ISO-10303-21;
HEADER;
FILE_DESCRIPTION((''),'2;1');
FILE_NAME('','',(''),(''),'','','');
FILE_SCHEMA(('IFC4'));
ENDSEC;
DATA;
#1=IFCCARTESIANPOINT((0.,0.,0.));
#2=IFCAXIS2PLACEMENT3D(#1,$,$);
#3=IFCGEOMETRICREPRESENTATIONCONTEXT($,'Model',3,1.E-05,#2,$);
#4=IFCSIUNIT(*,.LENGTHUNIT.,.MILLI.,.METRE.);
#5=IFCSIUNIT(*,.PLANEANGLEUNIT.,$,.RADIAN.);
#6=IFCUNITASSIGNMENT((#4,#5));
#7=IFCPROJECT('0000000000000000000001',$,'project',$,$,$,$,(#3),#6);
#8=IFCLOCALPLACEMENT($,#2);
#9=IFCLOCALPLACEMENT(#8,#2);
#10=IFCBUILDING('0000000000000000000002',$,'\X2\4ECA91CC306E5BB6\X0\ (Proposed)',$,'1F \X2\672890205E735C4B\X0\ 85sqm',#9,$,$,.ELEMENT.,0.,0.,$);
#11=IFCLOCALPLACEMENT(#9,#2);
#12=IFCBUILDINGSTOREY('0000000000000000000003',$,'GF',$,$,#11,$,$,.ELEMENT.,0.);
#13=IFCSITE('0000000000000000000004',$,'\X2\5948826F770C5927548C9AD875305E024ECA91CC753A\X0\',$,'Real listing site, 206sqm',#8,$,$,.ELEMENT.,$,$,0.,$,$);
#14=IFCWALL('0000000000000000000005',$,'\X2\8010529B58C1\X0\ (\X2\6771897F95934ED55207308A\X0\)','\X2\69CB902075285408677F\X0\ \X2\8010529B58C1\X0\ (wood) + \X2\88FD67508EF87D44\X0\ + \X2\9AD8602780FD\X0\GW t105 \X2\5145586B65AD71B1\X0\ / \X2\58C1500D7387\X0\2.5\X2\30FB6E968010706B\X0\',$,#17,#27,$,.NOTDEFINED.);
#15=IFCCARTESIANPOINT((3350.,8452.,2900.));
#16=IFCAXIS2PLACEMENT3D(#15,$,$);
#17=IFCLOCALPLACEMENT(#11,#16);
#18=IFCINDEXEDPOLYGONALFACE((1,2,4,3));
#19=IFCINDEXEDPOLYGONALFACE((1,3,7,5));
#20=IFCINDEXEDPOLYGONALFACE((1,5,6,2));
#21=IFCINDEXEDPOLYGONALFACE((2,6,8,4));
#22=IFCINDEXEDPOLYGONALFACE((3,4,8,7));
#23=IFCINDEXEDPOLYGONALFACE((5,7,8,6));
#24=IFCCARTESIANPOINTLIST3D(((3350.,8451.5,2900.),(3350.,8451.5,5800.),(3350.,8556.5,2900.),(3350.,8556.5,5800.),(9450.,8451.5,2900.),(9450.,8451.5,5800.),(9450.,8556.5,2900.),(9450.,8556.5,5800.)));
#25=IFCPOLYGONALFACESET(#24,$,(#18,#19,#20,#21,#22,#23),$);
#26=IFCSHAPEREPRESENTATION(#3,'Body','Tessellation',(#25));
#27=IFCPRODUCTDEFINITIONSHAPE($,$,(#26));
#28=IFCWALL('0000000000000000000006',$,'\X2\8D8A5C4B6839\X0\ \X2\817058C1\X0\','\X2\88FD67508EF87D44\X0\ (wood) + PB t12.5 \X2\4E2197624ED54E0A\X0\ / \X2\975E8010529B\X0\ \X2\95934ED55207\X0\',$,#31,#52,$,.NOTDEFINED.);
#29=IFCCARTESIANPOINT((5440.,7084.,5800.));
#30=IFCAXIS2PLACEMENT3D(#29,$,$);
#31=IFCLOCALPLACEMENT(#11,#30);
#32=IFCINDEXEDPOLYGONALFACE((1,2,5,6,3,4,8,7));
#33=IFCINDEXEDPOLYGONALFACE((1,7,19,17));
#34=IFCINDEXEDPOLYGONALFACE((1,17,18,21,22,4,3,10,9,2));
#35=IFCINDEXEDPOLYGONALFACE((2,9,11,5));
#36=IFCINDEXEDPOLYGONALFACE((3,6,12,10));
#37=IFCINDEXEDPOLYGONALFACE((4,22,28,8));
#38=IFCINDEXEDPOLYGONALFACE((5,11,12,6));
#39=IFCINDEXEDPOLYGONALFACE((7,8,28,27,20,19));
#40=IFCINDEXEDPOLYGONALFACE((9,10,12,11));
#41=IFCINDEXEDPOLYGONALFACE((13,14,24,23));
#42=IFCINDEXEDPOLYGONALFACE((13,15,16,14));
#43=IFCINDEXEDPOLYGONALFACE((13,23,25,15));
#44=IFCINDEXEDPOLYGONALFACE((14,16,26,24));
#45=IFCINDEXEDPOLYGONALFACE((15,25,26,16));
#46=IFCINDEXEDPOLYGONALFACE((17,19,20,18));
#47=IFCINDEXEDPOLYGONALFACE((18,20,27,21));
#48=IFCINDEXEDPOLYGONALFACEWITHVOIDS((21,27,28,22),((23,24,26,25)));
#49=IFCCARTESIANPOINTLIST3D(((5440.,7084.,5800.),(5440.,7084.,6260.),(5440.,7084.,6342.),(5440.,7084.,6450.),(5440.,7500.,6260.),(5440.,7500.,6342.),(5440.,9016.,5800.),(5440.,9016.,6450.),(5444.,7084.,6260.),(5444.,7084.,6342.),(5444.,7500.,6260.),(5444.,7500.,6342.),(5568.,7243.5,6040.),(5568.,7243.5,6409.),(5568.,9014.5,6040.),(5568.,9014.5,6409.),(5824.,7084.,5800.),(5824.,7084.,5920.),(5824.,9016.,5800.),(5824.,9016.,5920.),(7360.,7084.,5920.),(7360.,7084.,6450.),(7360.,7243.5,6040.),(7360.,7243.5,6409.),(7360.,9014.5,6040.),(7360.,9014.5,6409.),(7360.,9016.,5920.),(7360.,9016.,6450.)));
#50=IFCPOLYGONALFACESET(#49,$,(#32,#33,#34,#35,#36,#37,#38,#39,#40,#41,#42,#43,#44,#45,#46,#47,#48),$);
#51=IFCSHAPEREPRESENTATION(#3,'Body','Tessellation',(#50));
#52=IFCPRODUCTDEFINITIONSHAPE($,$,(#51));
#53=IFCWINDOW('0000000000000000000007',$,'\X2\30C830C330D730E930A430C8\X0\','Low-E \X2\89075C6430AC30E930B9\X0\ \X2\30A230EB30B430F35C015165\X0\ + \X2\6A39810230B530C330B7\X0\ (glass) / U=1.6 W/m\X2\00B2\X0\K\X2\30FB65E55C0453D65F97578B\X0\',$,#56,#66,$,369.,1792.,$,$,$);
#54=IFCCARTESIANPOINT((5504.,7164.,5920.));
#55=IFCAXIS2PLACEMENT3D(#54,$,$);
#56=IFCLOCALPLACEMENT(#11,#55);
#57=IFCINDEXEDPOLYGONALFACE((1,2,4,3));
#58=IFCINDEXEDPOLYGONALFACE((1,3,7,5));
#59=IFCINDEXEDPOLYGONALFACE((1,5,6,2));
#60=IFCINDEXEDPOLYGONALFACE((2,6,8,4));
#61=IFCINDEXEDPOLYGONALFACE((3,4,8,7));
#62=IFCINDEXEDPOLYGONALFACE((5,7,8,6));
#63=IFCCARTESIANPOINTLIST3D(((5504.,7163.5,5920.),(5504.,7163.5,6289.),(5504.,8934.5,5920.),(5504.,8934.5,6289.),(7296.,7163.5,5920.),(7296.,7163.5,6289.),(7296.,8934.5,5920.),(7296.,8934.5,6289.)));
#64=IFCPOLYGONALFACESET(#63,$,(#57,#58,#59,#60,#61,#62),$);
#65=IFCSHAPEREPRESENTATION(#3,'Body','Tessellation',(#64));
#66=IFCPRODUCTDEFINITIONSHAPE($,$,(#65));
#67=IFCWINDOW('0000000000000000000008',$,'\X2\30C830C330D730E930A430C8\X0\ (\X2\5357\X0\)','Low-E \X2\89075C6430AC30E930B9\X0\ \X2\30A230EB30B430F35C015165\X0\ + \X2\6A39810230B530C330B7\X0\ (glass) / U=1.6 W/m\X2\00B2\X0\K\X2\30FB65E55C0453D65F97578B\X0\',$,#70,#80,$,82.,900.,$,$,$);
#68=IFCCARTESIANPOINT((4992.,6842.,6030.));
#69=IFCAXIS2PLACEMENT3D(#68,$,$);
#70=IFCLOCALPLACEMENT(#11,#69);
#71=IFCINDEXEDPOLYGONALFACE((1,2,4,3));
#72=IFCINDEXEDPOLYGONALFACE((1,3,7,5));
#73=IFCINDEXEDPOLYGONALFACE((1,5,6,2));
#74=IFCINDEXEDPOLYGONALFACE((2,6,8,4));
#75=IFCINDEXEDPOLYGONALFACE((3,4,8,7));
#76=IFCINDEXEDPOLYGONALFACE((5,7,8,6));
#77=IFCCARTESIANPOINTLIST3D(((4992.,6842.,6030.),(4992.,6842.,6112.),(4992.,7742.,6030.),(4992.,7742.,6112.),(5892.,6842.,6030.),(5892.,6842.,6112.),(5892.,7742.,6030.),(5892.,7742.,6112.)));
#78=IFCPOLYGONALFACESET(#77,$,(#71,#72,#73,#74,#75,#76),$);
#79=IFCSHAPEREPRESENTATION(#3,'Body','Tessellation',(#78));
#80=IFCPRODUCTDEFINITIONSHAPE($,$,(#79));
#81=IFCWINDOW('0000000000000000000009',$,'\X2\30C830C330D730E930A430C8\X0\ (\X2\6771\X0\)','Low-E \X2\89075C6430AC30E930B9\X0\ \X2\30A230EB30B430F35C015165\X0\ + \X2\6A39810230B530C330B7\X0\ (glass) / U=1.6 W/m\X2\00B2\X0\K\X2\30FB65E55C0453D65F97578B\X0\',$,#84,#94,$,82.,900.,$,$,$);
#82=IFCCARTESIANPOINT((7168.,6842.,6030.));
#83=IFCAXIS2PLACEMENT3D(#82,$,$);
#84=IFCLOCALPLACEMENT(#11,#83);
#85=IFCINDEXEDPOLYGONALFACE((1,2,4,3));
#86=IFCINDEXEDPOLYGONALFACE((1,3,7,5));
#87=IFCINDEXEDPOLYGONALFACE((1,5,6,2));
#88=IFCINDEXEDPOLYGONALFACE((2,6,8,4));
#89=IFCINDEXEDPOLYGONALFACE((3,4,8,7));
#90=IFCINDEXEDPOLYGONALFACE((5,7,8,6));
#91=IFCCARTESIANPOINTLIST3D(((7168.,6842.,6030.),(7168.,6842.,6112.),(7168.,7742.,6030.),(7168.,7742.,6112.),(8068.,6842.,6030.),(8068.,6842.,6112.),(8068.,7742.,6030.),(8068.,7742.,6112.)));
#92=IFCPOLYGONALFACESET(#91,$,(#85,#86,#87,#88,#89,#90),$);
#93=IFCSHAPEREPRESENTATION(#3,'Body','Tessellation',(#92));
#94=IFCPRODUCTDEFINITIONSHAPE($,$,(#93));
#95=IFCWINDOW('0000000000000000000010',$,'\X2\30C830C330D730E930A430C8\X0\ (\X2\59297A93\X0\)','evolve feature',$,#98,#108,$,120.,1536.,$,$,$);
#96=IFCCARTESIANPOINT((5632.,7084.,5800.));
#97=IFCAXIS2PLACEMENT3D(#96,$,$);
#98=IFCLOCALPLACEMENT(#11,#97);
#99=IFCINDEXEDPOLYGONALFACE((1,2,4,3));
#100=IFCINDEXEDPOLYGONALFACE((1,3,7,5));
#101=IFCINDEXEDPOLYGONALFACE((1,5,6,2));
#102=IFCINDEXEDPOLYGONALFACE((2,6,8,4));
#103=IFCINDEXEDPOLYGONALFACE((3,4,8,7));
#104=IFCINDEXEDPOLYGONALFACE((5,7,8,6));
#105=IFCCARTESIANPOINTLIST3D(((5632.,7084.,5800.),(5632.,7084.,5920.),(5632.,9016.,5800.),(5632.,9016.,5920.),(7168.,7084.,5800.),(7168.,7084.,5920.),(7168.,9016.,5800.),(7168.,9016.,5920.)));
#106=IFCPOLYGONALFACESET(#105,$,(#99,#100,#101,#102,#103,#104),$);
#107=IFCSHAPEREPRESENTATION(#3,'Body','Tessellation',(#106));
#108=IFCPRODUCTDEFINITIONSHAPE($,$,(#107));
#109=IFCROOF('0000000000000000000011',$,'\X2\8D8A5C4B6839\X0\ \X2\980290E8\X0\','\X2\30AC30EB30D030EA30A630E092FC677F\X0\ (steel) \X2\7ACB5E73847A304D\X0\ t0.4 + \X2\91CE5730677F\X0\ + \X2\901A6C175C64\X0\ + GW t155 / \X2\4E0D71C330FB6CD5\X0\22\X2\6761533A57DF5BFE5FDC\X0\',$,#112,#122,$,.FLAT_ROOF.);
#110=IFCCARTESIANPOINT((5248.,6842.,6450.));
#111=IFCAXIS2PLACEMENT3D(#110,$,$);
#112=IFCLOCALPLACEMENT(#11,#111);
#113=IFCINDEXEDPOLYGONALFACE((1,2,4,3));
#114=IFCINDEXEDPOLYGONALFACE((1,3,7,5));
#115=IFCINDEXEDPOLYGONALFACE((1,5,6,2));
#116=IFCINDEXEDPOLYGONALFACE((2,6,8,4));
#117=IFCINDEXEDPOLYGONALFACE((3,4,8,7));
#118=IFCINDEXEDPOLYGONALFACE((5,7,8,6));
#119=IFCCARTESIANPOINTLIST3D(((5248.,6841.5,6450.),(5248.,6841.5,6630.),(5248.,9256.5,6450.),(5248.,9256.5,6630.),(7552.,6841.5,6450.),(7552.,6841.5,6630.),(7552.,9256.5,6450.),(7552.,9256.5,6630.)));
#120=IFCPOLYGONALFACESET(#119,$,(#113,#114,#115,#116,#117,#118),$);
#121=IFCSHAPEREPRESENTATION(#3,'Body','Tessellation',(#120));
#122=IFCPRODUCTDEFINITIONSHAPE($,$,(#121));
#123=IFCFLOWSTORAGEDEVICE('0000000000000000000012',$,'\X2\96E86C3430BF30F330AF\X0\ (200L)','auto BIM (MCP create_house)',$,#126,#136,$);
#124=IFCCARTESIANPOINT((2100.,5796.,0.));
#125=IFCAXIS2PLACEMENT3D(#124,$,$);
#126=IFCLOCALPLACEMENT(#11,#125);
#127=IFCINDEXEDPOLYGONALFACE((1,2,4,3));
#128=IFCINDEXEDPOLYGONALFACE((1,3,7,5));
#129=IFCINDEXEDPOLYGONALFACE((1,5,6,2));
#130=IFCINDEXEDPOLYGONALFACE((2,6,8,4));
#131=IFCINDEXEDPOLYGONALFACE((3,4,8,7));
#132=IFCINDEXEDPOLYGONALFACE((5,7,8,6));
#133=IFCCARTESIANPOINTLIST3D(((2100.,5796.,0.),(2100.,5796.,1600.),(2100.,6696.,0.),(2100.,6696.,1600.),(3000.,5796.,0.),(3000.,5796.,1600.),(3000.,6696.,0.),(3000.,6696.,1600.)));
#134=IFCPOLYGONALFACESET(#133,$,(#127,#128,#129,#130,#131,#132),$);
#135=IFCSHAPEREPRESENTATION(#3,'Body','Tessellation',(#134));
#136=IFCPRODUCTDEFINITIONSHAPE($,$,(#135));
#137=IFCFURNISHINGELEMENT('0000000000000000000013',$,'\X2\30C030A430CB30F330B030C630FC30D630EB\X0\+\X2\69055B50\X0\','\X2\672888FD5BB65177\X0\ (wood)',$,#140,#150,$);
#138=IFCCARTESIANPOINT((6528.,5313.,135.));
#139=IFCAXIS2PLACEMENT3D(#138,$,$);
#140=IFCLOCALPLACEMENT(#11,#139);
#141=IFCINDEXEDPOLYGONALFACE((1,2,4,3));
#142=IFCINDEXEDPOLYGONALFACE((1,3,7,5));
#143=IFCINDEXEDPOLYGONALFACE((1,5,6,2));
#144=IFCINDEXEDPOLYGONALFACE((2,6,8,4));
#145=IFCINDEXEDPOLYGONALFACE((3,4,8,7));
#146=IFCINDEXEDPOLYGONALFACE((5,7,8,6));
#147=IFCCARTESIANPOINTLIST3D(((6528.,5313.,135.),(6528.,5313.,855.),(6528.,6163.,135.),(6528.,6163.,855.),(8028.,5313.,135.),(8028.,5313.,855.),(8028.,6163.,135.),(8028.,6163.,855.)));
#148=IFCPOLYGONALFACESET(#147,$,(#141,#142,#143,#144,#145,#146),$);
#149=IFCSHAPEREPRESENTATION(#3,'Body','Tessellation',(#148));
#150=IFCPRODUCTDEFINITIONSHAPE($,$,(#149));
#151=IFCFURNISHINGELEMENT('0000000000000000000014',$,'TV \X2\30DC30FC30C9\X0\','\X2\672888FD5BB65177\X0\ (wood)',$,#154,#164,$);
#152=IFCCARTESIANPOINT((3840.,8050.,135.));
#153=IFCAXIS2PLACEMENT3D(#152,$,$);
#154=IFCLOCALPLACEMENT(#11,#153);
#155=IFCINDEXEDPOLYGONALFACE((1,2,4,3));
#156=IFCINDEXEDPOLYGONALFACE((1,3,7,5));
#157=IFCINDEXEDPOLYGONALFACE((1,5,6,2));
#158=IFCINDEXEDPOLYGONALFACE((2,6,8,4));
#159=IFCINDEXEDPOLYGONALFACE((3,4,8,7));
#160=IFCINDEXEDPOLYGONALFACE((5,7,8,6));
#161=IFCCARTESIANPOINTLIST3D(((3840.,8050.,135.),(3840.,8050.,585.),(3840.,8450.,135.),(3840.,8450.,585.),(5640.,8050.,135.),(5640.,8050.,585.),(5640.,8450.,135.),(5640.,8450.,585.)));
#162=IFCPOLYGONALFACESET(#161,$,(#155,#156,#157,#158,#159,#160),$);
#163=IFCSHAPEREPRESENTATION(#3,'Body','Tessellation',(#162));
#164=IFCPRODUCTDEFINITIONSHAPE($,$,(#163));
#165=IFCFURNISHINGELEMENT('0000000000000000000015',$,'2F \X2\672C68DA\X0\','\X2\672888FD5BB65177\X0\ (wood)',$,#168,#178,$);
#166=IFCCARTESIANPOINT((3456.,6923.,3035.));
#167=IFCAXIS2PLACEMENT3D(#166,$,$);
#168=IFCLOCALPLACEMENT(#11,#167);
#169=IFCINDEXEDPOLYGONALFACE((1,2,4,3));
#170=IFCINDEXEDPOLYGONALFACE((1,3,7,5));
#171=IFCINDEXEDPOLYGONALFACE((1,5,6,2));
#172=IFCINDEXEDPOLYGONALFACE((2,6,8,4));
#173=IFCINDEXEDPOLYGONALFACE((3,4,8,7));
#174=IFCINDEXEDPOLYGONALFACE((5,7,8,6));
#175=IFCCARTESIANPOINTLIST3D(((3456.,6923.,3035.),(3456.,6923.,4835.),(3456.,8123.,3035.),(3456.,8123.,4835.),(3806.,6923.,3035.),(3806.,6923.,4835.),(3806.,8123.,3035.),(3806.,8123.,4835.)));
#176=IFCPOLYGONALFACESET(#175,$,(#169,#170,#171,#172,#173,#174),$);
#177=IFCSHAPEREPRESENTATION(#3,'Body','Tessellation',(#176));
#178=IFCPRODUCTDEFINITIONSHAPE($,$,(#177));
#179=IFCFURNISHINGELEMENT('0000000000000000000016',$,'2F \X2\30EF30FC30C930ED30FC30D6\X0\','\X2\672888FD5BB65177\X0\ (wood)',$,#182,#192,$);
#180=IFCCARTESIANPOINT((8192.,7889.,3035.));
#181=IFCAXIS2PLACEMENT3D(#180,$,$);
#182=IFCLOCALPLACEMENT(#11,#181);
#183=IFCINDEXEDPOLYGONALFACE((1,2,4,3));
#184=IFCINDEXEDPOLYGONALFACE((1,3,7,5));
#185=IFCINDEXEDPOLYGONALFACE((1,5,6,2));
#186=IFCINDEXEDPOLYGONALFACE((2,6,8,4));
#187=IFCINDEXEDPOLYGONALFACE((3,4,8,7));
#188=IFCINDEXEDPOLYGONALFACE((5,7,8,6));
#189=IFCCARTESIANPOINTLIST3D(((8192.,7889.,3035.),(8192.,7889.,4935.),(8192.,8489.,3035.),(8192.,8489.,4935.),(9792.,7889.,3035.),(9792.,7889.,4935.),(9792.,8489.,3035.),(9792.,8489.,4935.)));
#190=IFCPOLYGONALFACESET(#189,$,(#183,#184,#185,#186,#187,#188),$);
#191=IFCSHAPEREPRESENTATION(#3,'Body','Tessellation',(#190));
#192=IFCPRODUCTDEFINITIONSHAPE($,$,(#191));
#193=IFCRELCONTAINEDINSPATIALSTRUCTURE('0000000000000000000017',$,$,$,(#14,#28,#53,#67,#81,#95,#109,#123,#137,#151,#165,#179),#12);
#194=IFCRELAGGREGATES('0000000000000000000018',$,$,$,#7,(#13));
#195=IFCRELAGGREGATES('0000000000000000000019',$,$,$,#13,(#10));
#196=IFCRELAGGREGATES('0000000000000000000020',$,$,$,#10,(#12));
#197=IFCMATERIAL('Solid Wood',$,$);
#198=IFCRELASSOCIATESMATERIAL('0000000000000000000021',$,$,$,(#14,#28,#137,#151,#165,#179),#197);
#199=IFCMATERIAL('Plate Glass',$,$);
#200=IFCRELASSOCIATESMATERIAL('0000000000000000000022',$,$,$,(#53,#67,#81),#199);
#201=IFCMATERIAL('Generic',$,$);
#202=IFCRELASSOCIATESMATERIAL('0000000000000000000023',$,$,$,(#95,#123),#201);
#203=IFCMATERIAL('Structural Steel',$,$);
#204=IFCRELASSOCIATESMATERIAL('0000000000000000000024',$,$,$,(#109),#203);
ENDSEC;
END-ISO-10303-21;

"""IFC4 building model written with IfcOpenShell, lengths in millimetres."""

from ifc_helpers import new_model, si_unit, frame, frame_2d, origin, place, context, project, spatial, rectangle, extrude, material, element, fill, save


model = new_model("IFC4")

# Units and contexts
model_context = context("Model", 3, precision=1e-05, world=origin())
ifc_project = project(units=[si_unit("LENGTHUNIT", "METRE", prefix="MILLI"), si_unit("PLANEANGLEUNIT", "RADIAN")], contexts=[model_context])

# Site, building, storey
site_placement = place(None, origin())
site = spatial("IfcSite", under=ifc_project, at=site_placement, Name="奈良県大和高田市今里町", ObjectType="Real listing site, 206sqm", CompositionType="ELEMENT", RefElevation=0.0)
building_placement = place(site_placement, origin())
building = spatial("IfcBuilding", under=site, at=building_placement, Name="今里の家 (Proposed)", ObjectType="1F 木造平屋 85sqm", CompositionType="ELEMENT", ElevationOfRefHeight=0.0, ElevationOfTerrain=0.0)
storey_placement = place(building_placement, origin())
storey = spatial("IfcBuildingStorey", under=building, at=storey_placement, Name="GF", CompositionType="ELEMENT", Elevation=0.0)

# Wall
ifc_material_1 = material(Name="Solid Wood")
wall_1_placement = place(storey_placement, frame((3350.0, 8452.0, 2900.0)))
element("IfcWall", 1, at=wall_1_placement, inside=storey, material=ifc_material_1, Name="耐力壁 (東西間仕切り)", Description="構造用合板 耐力壁 (wood) + 製材軸組 + 高性能GW t105 充填断熱 / 壁倍率2.5・準耐火", PredefinedType="NOTDEFINED", context=model_context, shape_type="SweptSolid", body=[
    extrude(rectangle(XDim=6100.0, YDim=105.0, at=frame_2d((3050.0, 52.0))), frame((3350.0, 8452.0, 2900.0)), (0.0, 0.0, 1.0), 2900.0),
])

# Wall, openings, windows
wall_2_placement = place(storey_placement, frame((5440.0, 7084.0, 5800.0)))
wall_2 = element("IfcWall", 2, at=wall_2_placement, inside=storey, material=ifc_material_1, Name="越屋根 腰壁", Description="製材軸組 (wood) + PB t12.5 両面仕上 / 非耐力 間仕切", PredefinedType="NOTDEFINED", context=model_context, shape_type="SweptSolid", body=[
    extrude(rectangle(XDim=1920.0, YDim=1932.0, at=frame_2d((960.0, 966.0))), frame((5440.0, 7084.0, 5800.0)), (0.0, 0.0, 1.0), 650.0),
])
opening_1_placement = place(storey_placement, frame((5504.0, 7164.0, 5920.0)))
opening_1 = element("IfcOpeningElement", 3, at=opening_1_placement, cuts=wall_2, PredefinedType="NOTDEFINED", context=model_context, shape_type="SweptSolid", body=[
    extrude(rectangle(XDim=1792.0, YDim=1771.0, at=frame_2d((896.0, 885.0))), frame((5504.0, 7164.0, 5920.0)), (0.0, 0.0, 1.0), 369.0),
])
opening_2_placement = place(storey_placement, frame((4992.0, 6842.0, 6030.0)))
opening_2 = element("IfcOpeningElement", 4, at=opening_2_placement, cuts=wall_2, PredefinedType="NOTDEFINED", context=model_context, shape_type="SweptSolid", body=[
    extrude(rectangle(XDim=900.0, YDim=900.0, at=frame_2d((450.0, 450.0))), frame((4992.0, 6842.0, 6030.0)), (0.0, 0.0, 1.0), 82.0),
])
opening_3_placement = place(storey_placement, frame((7168.0, 6842.0, 6030.0)))
opening_3 = element("IfcOpeningElement", 5, at=opening_3_placement, cuts=wall_2, PredefinedType="NOTDEFINED", context=model_context, shape_type="SweptSolid", body=[
    extrude(rectangle(XDim=900.0, YDim=900.0, at=frame_2d((450.0, 450.0))), frame((7168.0, 6842.0, 6030.0)), (0.0, 0.0, 1.0), 82.0),
])
opening_4_placement = place(storey_placement, frame((5632.0, 7084.0, 5800.0)))
opening_4 = element("IfcOpeningElement", 6, at=opening_4_placement, cuts=wall_2, PredefinedType="NOTDEFINED", context=model_context, shape_type="SweptSolid", body=[
    extrude(rectangle(XDim=1536.0, YDim=1932.0, at=frame_2d((768.0, 966.0))), frame((5632.0, 7084.0, 5800.0)), (0.0, 0.0, 1.0), 120.0),
])
ifc_material_2 = material(Name="Plate Glass")
window_1_placement = place(storey_placement, frame((5504.0, 7164.0, 5920.0)))
window_1 = element("IfcWindow", 7, at=window_1_placement, inside=storey, material=ifc_material_2, Name="トップライト", Description="Low-E 複層ガラス アルゴン封入 + 樹脂サッシ (glass) / U=1.6 W/m²K・日射取得型", OverallHeight=369.0, OverallWidth=1792.0, context=model_context, shape_type="SweptSolid", body=[
    extrude(rectangle(XDim=1792.0, YDim=1771.0, at=frame_2d((896.0, 885.0))), frame((5504.0, 7164.0, 5920.0)), (0.0, 0.0, 1.0), 369.0),
])
fill(opening_1, window_1)
window_2_placement = place(storey_placement, frame((4992.0, 6842.0, 6030.0)))
window_2 = element("IfcWindow", 8, at=window_2_placement, inside=storey, material=ifc_material_2, Name="トップライト (南)", Description="Low-E 複層ガラス アルゴン封入 + 樹脂サッシ (glass) / U=1.6 W/m²K・日射取得型", OverallHeight=82.0, OverallWidth=900.0, context=model_context, shape_type="SweptSolid", body=[
    extrude(rectangle(XDim=900.0, YDim=900.0, at=frame_2d((450.0, 450.0))), frame((4992.0, 6842.0, 6030.0)), (0.0, 0.0, 1.0), 82.0),
])
fill(opening_2, window_2)
window_3_placement = place(storey_placement, frame((7168.0, 6842.0, 6030.0)))
window_3 = element("IfcWindow", 9, at=window_3_placement, inside=storey, material=ifc_material_2, Name="トップライト (東)", Description="Low-E 複層ガラス アルゴン封入 + 樹脂サッシ (glass) / U=1.6 W/m²K・日射取得型", OverallHeight=82.0, OverallWidth=900.0, context=model_context, shape_type="SweptSolid", body=[
    extrude(rectangle(XDim=900.0, YDim=900.0, at=frame_2d((450.0, 450.0))), frame((7168.0, 6842.0, 6030.0)), (0.0, 0.0, 1.0), 82.0),
])
fill(opening_3, window_3)
ifc_material_3 = material(Name="Generic")
window_4_placement = place(storey_placement, frame((5632.0, 7084.0, 5800.0)))
window_4 = element("IfcWindow", 10, at=window_4_placement, inside=storey, material=ifc_material_3, Name="トップライト (天窓)", Description="evolve feature", OverallHeight=120.0, OverallWidth=1536.0, context=model_context, shape_type="SweptSolid", body=[
    extrude(rectangle(XDim=1536.0, YDim=1932.0, at=frame_2d((768.0, 966.0))), frame((5632.0, 7084.0, 5800.0)), (0.0, 0.0, 1.0), 120.0),
])
fill(opening_4, window_4)

# Roof
ifc_material_4 = material(Name="Structural Steel")
roof_placement = place(storey_placement, frame((5248.0, 6842.0, 6450.0)))
element("IfcRoof", 11, at=roof_placement, inside=storey, material=ifc_material_4, Name="越屋根 頂部", Description="ガルバリウム鋼板 (steel) 立平葺き t0.4 + 野地板 + 通気層 + GW t155 / 不燃・法22条区域対応", PredefinedType="FLAT_ROOF", context=model_context, shape_type="SweptSolid", body=[
    extrude(rectangle(XDim=2304.0, YDim=2415.0, at=frame_2d((1152.0, 1207.0))), frame((5248.0, 6842.0, 6450.0)), (0.0, 0.0, 1.0), 180.0),
])

# Flow storage device
flow_storage_device_placement = place(storey_placement, frame((2100.0, 5796.0, 0.0)))
element("IfcFlowStorageDevice", 12, at=flow_storage_device_placement, inside=storey, material=ifc_material_3, Name="雨水タンク (200L)", Description="auto BIM (MCP create_house)", context=model_context, shape_type="SweptSolid", body=[
    extrude(rectangle(XDim=900.0, YDim=900.0, at=frame_2d((450.0, 450.0))), frame((2100.0, 5796.0, 0.0)), (0.0, 0.0, 1.0), 1600.0),
])

# Furnishing elements
furnishing_1_placement = place(storey_placement, frame((6528.0, 5313.0, 135.0)))
element("IfcFurnishingElement", 13, at=furnishing_1_placement, inside=storey, material=ifc_material_1, Name="ダイニングテーブル+椅子", Description="木製家具 (wood)", context=model_context, shape_type="SweptSolid", body=[
    extrude(rectangle(XDim=1500.0, YDim=850.0, at=frame_2d((750.0, 425.0))), frame((6528.0, 5313.0, 135.0)), (0.0, 0.0, 1.0), 720.0),
])
furnishing_2_placement = place(storey_placement, frame((3840.0, 8050.0, 135.0)))
element("IfcFurnishingElement", 14, at=furnishing_2_placement, inside=storey, material=ifc_material_1, Name="TV ボード", Description="木製家具 (wood)", context=model_context, shape_type="SweptSolid", body=[
    extrude(rectangle(XDim=1800.0, YDim=400.0, at=frame_2d((900.0, 200.0))), frame((3840.0, 8050.0, 135.0)), (0.0, 0.0, 1.0), 450.0),
])
furnishing_3_placement = place(storey_placement, frame((3456.0, 6923.0, 3035.0)))
element("IfcFurnishingElement", 15, at=furnishing_3_placement, inside=storey, material=ifc_material_1, Name="2F 本棚", Description="木製家具 (wood)", context=model_context, shape_type="SweptSolid", body=[
    extrude(rectangle(XDim=350.0, YDim=1200.0, at=frame_2d((175.0, 600.0))), frame((3456.0, 6923.0, 3035.0)), (0.0, 0.0, 1.0), 1800.0),
])
furnishing_4_placement = place(storey_placement, frame((8192.0, 7889.0, 3035.0)))
element("IfcFurnishingElement", 16, at=furnishing_4_placement, inside=storey, material=ifc_material_1, Name="2F ワードローブ", Description="木製家具 (wood)", context=model_context, shape_type="SweptSolid", body=[
    extrude(rectangle(XDim=1600.0, YDim=600.0, at=frame_2d((800.0, 300.0))), frame((8192.0, 7889.0, 3035.0)), (0.0, 0.0, 1.0), 1900.0),
])

save(model, "model.ifc")
